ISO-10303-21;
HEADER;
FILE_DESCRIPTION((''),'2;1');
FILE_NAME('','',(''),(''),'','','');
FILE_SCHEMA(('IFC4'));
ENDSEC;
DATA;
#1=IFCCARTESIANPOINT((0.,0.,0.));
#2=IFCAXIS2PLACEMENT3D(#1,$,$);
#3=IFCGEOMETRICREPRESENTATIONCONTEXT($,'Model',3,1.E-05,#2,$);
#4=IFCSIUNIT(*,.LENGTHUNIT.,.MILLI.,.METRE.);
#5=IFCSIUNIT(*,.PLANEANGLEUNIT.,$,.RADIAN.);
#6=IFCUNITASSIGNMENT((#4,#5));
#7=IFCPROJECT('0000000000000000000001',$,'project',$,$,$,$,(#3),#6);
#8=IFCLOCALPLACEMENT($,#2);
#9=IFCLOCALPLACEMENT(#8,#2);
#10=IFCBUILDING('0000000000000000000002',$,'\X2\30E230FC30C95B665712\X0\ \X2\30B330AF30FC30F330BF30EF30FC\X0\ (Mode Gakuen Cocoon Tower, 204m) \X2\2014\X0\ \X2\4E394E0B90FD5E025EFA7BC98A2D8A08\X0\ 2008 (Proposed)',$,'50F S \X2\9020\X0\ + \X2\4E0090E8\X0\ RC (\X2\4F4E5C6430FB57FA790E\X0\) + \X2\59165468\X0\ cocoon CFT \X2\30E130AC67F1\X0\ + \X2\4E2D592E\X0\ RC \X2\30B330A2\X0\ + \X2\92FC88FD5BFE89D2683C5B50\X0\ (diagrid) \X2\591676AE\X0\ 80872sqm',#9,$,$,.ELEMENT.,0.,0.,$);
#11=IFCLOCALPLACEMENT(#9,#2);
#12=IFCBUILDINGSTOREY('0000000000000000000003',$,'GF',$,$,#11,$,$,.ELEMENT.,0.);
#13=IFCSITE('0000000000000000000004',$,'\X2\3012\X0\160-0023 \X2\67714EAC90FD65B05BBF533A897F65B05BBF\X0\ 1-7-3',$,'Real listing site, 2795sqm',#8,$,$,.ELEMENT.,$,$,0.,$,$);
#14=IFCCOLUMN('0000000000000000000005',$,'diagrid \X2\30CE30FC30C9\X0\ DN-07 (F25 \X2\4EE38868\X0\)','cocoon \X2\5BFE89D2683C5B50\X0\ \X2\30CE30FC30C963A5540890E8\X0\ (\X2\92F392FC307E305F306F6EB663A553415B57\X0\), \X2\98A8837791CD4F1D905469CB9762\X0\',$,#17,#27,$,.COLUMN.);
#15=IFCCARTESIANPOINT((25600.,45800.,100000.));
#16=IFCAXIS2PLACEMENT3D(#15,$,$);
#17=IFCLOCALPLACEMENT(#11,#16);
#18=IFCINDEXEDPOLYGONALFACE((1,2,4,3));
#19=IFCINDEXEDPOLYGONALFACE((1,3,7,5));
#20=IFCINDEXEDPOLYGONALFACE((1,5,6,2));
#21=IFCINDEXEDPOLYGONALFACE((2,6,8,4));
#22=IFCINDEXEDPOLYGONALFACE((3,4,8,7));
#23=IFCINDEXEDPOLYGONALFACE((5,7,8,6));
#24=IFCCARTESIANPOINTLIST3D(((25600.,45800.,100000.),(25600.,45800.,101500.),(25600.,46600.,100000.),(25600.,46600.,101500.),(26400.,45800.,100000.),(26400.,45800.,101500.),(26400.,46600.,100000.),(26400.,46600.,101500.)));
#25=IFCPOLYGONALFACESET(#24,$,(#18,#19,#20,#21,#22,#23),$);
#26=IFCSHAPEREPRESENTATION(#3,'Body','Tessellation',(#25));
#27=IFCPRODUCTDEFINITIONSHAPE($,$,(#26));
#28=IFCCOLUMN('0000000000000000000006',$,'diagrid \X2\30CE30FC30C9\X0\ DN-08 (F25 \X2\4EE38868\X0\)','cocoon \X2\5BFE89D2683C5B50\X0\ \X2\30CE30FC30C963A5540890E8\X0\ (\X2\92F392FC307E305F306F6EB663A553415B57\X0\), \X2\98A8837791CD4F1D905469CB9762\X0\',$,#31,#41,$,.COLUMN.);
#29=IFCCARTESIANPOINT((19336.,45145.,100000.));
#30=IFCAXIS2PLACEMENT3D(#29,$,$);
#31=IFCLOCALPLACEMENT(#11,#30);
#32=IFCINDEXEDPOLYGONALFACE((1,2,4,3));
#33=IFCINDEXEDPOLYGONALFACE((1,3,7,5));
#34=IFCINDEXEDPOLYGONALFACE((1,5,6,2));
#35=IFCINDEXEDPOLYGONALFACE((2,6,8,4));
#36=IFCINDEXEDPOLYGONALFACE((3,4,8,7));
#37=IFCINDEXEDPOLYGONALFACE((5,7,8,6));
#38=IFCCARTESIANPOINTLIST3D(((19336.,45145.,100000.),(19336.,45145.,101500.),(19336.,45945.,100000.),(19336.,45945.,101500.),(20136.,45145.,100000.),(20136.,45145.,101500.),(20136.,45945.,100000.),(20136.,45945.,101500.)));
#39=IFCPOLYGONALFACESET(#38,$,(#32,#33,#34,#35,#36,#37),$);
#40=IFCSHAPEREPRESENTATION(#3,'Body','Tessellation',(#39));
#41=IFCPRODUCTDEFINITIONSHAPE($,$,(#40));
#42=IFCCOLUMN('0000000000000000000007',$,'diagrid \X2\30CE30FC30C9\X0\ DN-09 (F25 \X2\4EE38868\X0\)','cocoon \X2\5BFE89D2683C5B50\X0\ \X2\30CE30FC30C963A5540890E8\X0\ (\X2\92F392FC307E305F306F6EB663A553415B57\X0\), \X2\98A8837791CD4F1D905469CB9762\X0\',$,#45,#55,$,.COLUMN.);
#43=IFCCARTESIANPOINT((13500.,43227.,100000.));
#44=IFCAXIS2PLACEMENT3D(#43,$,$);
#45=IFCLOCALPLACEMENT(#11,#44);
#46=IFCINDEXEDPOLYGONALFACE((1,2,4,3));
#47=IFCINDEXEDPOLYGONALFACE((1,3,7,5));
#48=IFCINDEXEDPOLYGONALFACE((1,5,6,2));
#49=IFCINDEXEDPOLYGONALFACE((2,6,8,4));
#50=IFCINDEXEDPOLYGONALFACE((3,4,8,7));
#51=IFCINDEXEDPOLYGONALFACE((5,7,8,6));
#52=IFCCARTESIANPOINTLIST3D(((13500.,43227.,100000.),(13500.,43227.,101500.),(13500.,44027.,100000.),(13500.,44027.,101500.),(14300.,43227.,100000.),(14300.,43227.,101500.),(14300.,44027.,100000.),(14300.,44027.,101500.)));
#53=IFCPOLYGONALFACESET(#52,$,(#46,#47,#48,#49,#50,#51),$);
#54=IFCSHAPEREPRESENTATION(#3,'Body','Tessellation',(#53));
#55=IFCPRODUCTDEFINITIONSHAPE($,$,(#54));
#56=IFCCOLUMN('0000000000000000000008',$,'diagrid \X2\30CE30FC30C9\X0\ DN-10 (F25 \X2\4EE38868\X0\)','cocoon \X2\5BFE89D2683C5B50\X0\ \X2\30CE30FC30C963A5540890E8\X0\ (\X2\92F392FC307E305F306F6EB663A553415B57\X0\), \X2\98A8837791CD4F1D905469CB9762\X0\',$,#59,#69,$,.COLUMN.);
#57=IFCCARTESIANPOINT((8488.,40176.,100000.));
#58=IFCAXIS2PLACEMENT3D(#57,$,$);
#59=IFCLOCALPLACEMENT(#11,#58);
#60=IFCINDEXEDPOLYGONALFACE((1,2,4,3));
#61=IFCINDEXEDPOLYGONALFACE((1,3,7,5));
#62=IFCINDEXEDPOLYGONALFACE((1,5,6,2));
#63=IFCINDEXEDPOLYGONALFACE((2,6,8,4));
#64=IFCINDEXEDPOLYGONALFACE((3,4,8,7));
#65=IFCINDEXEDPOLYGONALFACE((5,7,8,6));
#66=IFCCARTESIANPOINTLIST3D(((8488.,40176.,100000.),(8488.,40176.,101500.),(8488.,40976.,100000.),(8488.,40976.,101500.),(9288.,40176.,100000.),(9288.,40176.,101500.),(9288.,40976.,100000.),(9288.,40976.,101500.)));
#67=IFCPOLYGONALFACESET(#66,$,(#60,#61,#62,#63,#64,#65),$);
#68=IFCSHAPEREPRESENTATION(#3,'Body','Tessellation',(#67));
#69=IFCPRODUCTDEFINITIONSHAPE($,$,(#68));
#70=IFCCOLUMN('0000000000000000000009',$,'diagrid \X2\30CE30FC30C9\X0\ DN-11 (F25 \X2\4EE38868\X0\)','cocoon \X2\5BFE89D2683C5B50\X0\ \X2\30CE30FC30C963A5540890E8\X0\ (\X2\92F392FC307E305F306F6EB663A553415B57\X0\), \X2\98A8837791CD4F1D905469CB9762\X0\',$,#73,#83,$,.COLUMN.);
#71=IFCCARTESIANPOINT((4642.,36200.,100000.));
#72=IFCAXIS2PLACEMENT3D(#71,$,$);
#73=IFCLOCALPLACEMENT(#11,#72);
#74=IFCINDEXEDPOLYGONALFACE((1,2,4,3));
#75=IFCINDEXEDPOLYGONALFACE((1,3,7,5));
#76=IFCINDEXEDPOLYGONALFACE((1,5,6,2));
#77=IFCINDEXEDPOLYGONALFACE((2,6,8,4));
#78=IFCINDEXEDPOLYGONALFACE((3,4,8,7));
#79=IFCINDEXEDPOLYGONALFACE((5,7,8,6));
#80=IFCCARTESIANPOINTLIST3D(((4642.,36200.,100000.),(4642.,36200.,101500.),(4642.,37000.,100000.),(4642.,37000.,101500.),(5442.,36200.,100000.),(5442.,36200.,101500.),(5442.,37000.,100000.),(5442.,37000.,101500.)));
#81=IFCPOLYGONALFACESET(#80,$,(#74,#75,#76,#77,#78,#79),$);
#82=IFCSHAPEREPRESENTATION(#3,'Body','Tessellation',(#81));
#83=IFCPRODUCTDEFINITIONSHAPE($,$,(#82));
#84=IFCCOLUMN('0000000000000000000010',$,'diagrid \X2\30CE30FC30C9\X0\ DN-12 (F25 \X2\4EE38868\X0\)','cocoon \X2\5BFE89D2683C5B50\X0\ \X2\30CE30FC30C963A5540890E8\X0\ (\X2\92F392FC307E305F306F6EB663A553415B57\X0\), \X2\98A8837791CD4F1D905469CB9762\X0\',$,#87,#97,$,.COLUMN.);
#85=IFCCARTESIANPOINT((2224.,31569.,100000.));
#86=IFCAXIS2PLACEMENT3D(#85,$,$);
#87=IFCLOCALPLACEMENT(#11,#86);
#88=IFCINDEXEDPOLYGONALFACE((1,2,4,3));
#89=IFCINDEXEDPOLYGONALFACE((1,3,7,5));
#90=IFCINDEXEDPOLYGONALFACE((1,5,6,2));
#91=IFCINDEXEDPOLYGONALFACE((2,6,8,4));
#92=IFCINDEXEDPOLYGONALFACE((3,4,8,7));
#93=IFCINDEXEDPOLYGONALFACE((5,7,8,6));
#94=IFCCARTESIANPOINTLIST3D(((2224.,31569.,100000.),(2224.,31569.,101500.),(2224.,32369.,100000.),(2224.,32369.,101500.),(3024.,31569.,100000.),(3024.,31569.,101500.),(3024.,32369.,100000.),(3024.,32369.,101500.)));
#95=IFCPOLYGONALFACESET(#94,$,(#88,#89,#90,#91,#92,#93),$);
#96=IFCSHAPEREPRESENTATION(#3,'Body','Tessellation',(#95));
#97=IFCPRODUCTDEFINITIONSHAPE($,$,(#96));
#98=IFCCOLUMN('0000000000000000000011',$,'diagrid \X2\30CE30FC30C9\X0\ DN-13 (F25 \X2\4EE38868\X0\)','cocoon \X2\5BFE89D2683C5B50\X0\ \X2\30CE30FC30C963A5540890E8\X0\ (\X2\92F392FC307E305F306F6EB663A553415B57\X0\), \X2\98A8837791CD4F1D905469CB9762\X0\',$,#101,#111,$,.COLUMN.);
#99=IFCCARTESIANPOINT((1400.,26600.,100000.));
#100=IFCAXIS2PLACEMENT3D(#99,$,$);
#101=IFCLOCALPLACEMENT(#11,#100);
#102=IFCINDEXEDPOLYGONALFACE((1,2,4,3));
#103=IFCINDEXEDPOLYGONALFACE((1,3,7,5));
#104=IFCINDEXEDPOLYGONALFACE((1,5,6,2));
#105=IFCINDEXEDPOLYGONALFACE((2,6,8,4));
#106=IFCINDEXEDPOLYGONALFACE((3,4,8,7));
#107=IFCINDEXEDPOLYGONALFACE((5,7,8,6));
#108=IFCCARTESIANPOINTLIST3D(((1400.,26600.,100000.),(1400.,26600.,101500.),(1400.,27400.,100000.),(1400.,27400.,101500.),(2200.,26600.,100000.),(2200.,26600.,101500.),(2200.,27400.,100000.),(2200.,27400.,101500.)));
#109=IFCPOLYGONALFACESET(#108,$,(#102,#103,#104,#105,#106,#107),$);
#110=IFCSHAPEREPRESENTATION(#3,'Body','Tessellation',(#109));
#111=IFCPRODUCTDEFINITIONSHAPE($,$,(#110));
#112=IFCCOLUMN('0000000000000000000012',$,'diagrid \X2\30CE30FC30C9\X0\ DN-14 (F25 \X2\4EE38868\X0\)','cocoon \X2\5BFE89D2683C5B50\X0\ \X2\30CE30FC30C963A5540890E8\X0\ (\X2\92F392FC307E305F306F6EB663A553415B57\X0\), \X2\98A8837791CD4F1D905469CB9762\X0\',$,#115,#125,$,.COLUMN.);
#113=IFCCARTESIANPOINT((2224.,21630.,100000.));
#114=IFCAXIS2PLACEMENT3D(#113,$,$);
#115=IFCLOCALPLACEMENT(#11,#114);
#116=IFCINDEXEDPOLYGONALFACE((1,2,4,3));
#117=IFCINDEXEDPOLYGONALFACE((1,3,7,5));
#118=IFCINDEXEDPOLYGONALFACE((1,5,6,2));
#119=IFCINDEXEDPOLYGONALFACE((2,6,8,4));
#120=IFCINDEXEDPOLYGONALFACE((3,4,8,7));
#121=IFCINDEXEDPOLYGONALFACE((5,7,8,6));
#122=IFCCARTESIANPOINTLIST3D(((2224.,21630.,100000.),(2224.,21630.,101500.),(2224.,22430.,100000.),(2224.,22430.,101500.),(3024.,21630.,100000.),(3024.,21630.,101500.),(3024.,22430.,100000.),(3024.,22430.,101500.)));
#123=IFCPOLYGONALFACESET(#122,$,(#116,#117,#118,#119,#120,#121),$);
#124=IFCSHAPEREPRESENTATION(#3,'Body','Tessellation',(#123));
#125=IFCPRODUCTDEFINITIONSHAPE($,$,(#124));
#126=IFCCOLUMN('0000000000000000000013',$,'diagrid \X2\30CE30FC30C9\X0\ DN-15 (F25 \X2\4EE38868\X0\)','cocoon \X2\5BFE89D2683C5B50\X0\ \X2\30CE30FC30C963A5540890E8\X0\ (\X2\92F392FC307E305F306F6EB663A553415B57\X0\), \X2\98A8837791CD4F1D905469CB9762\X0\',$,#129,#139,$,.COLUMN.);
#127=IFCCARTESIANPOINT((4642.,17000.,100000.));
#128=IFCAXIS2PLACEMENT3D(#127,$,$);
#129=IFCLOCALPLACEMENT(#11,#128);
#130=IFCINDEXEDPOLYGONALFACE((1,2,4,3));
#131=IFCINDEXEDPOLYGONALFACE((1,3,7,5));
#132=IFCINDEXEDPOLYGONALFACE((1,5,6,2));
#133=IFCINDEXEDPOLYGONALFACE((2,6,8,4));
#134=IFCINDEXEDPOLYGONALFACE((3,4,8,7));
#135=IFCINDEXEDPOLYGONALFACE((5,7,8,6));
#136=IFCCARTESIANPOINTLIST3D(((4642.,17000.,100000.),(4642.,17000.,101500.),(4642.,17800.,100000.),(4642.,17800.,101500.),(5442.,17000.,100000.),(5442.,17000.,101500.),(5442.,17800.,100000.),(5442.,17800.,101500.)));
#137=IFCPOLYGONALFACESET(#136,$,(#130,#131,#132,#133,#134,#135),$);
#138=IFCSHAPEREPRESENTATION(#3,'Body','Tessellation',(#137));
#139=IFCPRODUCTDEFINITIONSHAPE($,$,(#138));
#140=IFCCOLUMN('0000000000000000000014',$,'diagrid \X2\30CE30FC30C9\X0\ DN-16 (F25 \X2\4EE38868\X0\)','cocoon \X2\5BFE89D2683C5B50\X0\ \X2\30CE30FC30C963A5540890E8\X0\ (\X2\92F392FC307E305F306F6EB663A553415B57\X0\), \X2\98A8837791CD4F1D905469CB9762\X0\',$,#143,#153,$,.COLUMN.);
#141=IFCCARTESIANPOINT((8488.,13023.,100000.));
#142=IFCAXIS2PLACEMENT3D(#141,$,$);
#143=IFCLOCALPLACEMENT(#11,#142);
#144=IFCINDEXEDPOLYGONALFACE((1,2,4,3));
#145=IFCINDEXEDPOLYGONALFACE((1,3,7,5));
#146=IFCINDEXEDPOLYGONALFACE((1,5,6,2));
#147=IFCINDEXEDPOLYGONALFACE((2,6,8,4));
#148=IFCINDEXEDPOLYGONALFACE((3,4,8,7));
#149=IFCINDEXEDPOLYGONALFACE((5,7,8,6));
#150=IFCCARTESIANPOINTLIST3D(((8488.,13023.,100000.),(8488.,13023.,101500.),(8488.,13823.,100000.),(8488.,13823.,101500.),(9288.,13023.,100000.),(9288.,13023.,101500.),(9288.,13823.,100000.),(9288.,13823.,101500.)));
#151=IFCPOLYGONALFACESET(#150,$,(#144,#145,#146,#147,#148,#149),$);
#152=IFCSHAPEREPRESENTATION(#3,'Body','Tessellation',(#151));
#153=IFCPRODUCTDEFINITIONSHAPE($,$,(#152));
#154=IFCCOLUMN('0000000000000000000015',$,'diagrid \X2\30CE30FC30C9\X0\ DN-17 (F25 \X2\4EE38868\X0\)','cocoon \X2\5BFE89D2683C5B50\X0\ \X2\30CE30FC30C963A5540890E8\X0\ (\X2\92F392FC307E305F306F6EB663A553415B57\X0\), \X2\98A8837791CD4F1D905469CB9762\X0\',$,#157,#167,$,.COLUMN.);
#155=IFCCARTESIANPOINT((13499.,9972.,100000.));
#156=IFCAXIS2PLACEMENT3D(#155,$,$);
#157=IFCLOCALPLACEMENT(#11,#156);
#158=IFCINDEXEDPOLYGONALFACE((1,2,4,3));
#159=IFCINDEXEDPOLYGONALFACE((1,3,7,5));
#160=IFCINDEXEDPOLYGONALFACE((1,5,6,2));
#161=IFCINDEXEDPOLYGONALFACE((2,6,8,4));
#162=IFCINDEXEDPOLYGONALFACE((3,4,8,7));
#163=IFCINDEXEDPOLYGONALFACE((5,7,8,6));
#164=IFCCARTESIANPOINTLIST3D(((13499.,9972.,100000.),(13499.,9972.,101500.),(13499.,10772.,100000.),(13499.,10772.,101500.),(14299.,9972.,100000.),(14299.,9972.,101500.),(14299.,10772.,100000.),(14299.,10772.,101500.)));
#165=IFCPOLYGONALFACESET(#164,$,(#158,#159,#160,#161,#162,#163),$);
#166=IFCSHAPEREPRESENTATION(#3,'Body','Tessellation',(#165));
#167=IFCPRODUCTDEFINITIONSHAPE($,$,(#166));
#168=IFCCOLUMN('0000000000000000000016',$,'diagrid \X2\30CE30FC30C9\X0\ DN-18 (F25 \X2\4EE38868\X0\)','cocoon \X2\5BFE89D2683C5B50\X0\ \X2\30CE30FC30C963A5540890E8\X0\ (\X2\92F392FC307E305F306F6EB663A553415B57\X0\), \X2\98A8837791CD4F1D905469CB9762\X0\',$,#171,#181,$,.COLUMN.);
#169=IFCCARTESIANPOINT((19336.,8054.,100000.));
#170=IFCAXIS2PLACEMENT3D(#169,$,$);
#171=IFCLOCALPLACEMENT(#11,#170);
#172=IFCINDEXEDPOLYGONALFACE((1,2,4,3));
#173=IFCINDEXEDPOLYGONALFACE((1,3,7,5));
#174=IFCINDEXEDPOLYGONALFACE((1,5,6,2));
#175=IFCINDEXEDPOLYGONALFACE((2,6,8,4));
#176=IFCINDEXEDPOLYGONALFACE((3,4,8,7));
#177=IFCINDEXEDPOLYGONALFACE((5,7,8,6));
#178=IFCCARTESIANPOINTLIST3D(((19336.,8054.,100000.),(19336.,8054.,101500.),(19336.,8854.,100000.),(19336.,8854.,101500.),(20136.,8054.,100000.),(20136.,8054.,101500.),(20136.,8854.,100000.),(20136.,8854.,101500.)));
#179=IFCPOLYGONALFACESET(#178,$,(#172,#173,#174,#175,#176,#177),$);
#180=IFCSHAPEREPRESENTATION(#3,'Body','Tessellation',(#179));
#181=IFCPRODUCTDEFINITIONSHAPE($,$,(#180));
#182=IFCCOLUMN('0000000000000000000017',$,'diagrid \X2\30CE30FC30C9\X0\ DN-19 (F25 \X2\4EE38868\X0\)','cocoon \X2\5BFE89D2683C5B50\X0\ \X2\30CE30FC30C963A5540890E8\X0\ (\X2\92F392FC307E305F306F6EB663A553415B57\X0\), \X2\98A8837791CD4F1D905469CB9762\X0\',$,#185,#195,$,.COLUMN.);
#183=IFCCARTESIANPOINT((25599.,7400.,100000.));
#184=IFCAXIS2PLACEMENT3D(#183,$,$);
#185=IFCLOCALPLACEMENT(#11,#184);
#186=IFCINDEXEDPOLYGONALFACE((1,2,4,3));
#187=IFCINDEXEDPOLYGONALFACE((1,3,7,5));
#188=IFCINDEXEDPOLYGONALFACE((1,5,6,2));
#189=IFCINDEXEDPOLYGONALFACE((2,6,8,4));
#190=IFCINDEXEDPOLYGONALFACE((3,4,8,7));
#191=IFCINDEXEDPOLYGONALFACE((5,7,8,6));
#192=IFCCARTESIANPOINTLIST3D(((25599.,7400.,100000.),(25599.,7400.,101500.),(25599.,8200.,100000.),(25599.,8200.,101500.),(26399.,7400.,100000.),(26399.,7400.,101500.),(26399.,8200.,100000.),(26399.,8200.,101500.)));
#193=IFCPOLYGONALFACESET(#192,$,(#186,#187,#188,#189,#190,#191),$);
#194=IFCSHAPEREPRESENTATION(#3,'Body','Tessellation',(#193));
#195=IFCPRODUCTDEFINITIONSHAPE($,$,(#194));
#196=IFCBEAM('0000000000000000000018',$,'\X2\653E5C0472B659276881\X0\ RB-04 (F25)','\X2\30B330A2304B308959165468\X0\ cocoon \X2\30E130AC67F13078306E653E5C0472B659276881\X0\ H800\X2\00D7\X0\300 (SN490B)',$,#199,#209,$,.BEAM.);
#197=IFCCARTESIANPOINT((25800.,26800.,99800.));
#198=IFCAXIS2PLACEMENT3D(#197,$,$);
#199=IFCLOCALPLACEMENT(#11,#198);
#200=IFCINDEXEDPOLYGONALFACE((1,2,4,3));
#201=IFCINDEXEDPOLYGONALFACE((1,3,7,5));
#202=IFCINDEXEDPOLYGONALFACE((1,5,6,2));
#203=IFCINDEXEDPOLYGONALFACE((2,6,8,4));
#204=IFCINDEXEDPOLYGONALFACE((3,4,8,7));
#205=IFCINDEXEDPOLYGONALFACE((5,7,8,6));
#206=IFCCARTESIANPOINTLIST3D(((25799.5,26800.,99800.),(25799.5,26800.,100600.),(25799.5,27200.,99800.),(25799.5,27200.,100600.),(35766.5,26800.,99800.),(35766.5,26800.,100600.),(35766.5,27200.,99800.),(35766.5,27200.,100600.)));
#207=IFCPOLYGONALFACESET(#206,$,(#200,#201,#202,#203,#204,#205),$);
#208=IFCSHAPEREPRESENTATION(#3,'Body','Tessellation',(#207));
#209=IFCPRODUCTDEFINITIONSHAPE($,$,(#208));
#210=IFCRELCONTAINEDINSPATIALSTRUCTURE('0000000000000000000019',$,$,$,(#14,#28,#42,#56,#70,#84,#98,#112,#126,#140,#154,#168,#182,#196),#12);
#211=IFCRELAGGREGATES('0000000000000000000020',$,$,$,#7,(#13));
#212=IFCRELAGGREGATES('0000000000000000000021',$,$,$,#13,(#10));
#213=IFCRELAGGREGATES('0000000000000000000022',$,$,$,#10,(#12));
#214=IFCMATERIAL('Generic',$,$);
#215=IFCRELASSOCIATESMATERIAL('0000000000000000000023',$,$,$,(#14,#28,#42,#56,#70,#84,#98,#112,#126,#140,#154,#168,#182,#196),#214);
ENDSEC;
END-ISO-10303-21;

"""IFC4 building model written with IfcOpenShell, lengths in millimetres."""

from ifc_helpers import new_model, si_unit, frame, frame_2d, origin, place, context, project, spatial, rectangle, extrude, material, element, save


model = new_model("IFC4")

# Units and contexts
model_context = context("Model", 3, precision=1e-05, world=origin())
ifc_project = project(units=[si_unit("LENGTHUNIT", "METRE", prefix="MILLI"), si_unit("PLANEANGLEUNIT", "RADIAN")], contexts=[model_context])

# Site, building, storey
site_placement = place(None, origin())
site = spatial("IfcSite", under=ifc_project, at=site_placement, Name="〒160-0023 東京都新宿区西新宿 1-7-3", ObjectType="Real listing site, 2795sqm", CompositionType="ELEMENT", RefElevation=0.0)
building_placement = place(site_placement, origin())
building = spatial("IfcBuilding", under=site, at=building_placement, Name="モード学園 コクーンタワー (Mode Gakuen Cocoon Tower, 204m) — 丹下都市建築設計 2008 (Proposed)", ObjectType="50F S 造 + 一部 RC (低層・基礎) + 外周 cocoon CFT メガ柱 + 中央 RC コア + 鋼製対角格子 (diagrid) 外皮 80872sqm", CompositionType="ELEMENT", ElevationOfRefHeight=0.0, ElevationOfTerrain=0.0)
storey_placement = place(building_placement, origin())
storey = spatial("IfcBuildingStorey", under=building, at=storey_placement, Name="GF", CompositionType="ELEMENT", Elevation=0.0)

# Columns
ifc_material_1 = material(Name="Generic")
column_1_placement = place(storey_placement, frame((25600.0, 45800.0, 100000.0)))
element("IfcColumn", 1, at=column_1_placement, inside=storey, material=ifc_material_1, Name="diagrid ノード DN-07 (F25 代表)", Description="cocoon 対角格子 ノード接合部 (鋳鋼または溶接十字), 風荷重伝達構面", PredefinedType="COLUMN", context=model_context, shape_type="SweptSolid", body=[
    extrude(rectangle(XDim=800.0, YDim=800.0, at=frame_2d((400.0, 400.0))), frame((25600.0, 45800.0, 100000.0)), (0.0, 0.0, 1.0), 1500.0),
])
column_2_placement = place(storey_placement, frame((19336.0, 45145.0, 100000.0)))
element("IfcColumn", 2, at=column_2_placement, inside=storey, material=ifc_material_1, Name="diagrid ノード DN-08 (F25 代表)", Description="cocoon 対角格子 ノード接合部 (鋳鋼または溶接十字), 風荷重伝達構面", PredefinedType="COLUMN", context=model_context, shape_type="SweptSolid", body=[
    extrude(rectangle(XDim=800.0, YDim=800.0, at=frame_2d((400.0, 400.0))), frame((19336.0, 45145.0, 100000.0)), (0.0, 0.0, 1.0), 1500.0),
])
column_3_placement = place(storey_placement, frame((13500.0, 43227.0, 100000.0)))
element("IfcColumn", 3, at=column_3_placement, inside=storey, material=ifc_material_1, Name="diagrid ノード DN-09 (F25 代表)", Description="cocoon 対角格子 ノード接合部 (鋳鋼または溶接十字), 風荷重伝達構面", PredefinedType="COLUMN", context=model_context, shape_type="SweptSolid", body=[
    extrude(rectangle(XDim=800.0, YDim=800.0, at=frame_2d((400.0, 400.0))), frame((13500.0, 43227.0, 100000.0)), (0.0, 0.0, 1.0), 1500.0),
])
column_4_placement = place(storey_placement, frame((8488.0, 40176.0, 100000.0)))
element("IfcColumn", 4, at=column_4_placement, inside=storey, material=ifc_material_1, Name="diagrid ノード DN-10 (F25 代表)", Description="cocoon 対角格子 ノード接合部 (鋳鋼または溶接十字), 風荷重伝達構面", PredefinedType="COLUMN", context=model_context, shape_type="SweptSolid", body=[
    extrude(rectangle(XDim=800.0, YDim=800.0, at=frame_2d((400.0, 400.0))), frame((8488.0, 40176.0, 100000.0)), (0.0, 0.0, 1.0), 1500.0),
])
column_5_placement = place(storey_placement, frame((4642.0, 36200.0, 100000.0)))
element("IfcColumn", 5, at=column_5_placement, inside=storey, material=ifc_material_1, Name="diagrid ノード DN-11 (F25 代表)", Description="cocoon 対角格子 ノード接合部 (鋳鋼または溶接十字), 風荷重伝達構面", PredefinedType="COLUMN", context=model_context, shape_type="SweptSolid", body=[
    extrude(rectangle(XDim=800.0, YDim=800.0, at=frame_2d((400.0, 400.0))), frame((4642.0, 36200.0, 100000.0)), (0.0, 0.0, 1.0), 1500.0),
])
column_6_placement = place(storey_placement, frame((2224.0, 31569.0, 100000.0)))
element("IfcColumn", 6, at=column_6_placement, inside=storey, material=ifc_material_1, Name="diagrid ノード DN-12 (F25 代表)", Description="cocoon 対角格子 ノード接合部 (鋳鋼または溶接十字), 風荷重伝達構面", PredefinedType="COLUMN", context=model_context, shape_type="SweptSolid", body=[
    extrude(rectangle(XDim=800.0, YDim=800.0, at=frame_2d((400.0, 400.0))), frame((2224.0, 31569.0, 100000.0)), (0.0, 0.0, 1.0), 1500.0),
])
column_7_placement = place(storey_placement, frame((1400.0, 26600.0, 100000.0)))
element("IfcColumn", 7, at=column_7_placement, inside=storey, material=ifc_material_1, Name="diagrid ノード DN-13 (F25 代表)", Description="cocoon 対角格子 ノード接合部 (鋳鋼または溶接十字), 風荷重伝達構面", PredefinedType="COLUMN", context=model_context, shape_type="SweptSolid", body=[
    extrude(rectangle(XDim=800.0, YDim=800.0, at=frame_2d((400.0, 400.0))), frame((1400.0, 26600.0, 100000.0)), (0.0, 0.0, 1.0), 1500.0),
])
column_8_placement = place(storey_placement, frame((2224.0, 21630.0, 100000.0)))
element("IfcColumn", 8, at=column_8_placement, inside=storey, material=ifc_material_1, Name="diagrid ノード DN-14 (F25 代表)", Description="cocoon 対角格子 ノード接合部 (鋳鋼または溶接十字), 風荷重伝達構面", PredefinedType="COLUMN", context=model_context, shape_type="SweptSolid", body=[
    extrude(rectangle(XDim=800.0, YDim=800.0, at=frame_2d((400.0, 400.0))), frame((2224.0, 21630.0, 100000.0)), (0.0, 0.0, 1.0), 1500.0),
])
column_9_placement = place(storey_placement, frame((4642.0, 17000.0, 100000.0)))
element("IfcColumn", 9, at=column_9_placement, inside=storey, material=ifc_material_1, Name="diagrid ノード DN-15 (F25 代表)", Description="cocoon 対角格子 ノード接合部 (鋳鋼または溶接十字), 風荷重伝達構面", PredefinedType="COLUMN", context=model_context, shape_type="SweptSolid", body=[
    extrude(rectangle(XDim=800.0, YDim=800.0, at=frame_2d((400.0, 400.0))), frame((4642.0, 17000.0, 100000.0)), (0.0, 0.0, 1.0), 1500.0),
])
column_10_placement = place(storey_placement, frame((8488.0, 13023.0, 100000.0)))
element("IfcColumn", 10, at=column_10_placement, inside=storey, material=ifc_material_1, Name="diagrid ノード DN-16 (F25 代表)", Description="cocoon 対角格子 ノード接合部 (鋳鋼または溶接十字), 風荷重伝達構面", PredefinedType="COLUMN", context=model_context, shape_type="SweptSolid", body=[
    extrude(rectangle(XDim=800.0, YDim=800.0, at=frame_2d((400.0, 400.0))), frame((8488.0, 13023.0, 100000.0)), (0.0, 0.0, 1.0), 1500.0),
])
column_11_placement = place(storey_placement, frame((13499.0, 9972.0, 100000.0)))
element("IfcColumn", 11, at=column_11_placement, inside=storey, material=ifc_material_1, Name="diagrid ノード DN-17 (F25 代表)", Description="cocoon 対角格子 ノード接合部 (鋳鋼または溶接十字), 風荷重伝達構面", PredefinedType="COLUMN", context=model_context, shape_type="SweptSolid", body=[
    extrude(rectangle(XDim=800.0, YDim=800.0, at=frame_2d((400.0, 400.0))), frame((13499.0, 9972.0, 100000.0)), (0.0, 0.0, 1.0), 1500.0),
])
column_12_placement = place(storey_placement, frame((19336.0, 8054.0, 100000.0)))
element("IfcColumn", 12, at=column_12_placement, inside=storey, material=ifc_material_1, Name="diagrid ノード DN-18 (F25 代表)", Description="cocoon 対角格子 ノード接合部 (鋳鋼または溶接十字), 風荷重伝達構面", PredefinedType="COLUMN", context=model_context, shape_type="SweptSolid", body=[
    extrude(rectangle(XDim=800.0, YDim=800.0, at=frame_2d((400.0, 400.0))), frame((19336.0, 8054.0, 100000.0)), (0.0, 0.0, 1.0), 1500.0),
])
column_13_placement = place(storey_placement, frame((25599.0, 7400.0, 100000.0)))
element("IfcColumn", 13, at=column_13_placement, inside=storey, material=ifc_material_1, Name="diagrid ノード DN-19 (F25 代表)", Description="cocoon 対角格子 ノード接合部 (鋳鋼または溶接十字), 風荷重伝達構面", PredefinedType="COLUMN", context=model_context, shape_type="SweptSolid", body=[
    extrude(rectangle(XDim=800.0, YDim=800.0, at=frame_2d((400.0, 400.0))), frame((25599.0, 7400.0, 100000.0)), (0.0, 0.0, 1.0), 1500.0),
])

# Beam
beam_1_placement = place(storey_placement, frame((25800.0, 26800.0, 99800.0)))
element("IfcBeam", 14, at=beam_1_placement, inside=storey, material=ifc_material_1, Name="放射状大梁 RB-04 (F25)", Description="コアから外周 cocoon メガ柱への放射状大梁 H800×300 (SN490B)", PredefinedType="BEAM", context=model_context, shape_type="SweptSolid", body=[
    extrude(rectangle(XDim=9967.0, YDim=400.0, at=frame_2d((4983.0, 200.0))), frame((25800.0, 26800.0, 99800.0)), (0.0, 0.0, 1.0), 800.0),
])

save(model, "model.ifc")
